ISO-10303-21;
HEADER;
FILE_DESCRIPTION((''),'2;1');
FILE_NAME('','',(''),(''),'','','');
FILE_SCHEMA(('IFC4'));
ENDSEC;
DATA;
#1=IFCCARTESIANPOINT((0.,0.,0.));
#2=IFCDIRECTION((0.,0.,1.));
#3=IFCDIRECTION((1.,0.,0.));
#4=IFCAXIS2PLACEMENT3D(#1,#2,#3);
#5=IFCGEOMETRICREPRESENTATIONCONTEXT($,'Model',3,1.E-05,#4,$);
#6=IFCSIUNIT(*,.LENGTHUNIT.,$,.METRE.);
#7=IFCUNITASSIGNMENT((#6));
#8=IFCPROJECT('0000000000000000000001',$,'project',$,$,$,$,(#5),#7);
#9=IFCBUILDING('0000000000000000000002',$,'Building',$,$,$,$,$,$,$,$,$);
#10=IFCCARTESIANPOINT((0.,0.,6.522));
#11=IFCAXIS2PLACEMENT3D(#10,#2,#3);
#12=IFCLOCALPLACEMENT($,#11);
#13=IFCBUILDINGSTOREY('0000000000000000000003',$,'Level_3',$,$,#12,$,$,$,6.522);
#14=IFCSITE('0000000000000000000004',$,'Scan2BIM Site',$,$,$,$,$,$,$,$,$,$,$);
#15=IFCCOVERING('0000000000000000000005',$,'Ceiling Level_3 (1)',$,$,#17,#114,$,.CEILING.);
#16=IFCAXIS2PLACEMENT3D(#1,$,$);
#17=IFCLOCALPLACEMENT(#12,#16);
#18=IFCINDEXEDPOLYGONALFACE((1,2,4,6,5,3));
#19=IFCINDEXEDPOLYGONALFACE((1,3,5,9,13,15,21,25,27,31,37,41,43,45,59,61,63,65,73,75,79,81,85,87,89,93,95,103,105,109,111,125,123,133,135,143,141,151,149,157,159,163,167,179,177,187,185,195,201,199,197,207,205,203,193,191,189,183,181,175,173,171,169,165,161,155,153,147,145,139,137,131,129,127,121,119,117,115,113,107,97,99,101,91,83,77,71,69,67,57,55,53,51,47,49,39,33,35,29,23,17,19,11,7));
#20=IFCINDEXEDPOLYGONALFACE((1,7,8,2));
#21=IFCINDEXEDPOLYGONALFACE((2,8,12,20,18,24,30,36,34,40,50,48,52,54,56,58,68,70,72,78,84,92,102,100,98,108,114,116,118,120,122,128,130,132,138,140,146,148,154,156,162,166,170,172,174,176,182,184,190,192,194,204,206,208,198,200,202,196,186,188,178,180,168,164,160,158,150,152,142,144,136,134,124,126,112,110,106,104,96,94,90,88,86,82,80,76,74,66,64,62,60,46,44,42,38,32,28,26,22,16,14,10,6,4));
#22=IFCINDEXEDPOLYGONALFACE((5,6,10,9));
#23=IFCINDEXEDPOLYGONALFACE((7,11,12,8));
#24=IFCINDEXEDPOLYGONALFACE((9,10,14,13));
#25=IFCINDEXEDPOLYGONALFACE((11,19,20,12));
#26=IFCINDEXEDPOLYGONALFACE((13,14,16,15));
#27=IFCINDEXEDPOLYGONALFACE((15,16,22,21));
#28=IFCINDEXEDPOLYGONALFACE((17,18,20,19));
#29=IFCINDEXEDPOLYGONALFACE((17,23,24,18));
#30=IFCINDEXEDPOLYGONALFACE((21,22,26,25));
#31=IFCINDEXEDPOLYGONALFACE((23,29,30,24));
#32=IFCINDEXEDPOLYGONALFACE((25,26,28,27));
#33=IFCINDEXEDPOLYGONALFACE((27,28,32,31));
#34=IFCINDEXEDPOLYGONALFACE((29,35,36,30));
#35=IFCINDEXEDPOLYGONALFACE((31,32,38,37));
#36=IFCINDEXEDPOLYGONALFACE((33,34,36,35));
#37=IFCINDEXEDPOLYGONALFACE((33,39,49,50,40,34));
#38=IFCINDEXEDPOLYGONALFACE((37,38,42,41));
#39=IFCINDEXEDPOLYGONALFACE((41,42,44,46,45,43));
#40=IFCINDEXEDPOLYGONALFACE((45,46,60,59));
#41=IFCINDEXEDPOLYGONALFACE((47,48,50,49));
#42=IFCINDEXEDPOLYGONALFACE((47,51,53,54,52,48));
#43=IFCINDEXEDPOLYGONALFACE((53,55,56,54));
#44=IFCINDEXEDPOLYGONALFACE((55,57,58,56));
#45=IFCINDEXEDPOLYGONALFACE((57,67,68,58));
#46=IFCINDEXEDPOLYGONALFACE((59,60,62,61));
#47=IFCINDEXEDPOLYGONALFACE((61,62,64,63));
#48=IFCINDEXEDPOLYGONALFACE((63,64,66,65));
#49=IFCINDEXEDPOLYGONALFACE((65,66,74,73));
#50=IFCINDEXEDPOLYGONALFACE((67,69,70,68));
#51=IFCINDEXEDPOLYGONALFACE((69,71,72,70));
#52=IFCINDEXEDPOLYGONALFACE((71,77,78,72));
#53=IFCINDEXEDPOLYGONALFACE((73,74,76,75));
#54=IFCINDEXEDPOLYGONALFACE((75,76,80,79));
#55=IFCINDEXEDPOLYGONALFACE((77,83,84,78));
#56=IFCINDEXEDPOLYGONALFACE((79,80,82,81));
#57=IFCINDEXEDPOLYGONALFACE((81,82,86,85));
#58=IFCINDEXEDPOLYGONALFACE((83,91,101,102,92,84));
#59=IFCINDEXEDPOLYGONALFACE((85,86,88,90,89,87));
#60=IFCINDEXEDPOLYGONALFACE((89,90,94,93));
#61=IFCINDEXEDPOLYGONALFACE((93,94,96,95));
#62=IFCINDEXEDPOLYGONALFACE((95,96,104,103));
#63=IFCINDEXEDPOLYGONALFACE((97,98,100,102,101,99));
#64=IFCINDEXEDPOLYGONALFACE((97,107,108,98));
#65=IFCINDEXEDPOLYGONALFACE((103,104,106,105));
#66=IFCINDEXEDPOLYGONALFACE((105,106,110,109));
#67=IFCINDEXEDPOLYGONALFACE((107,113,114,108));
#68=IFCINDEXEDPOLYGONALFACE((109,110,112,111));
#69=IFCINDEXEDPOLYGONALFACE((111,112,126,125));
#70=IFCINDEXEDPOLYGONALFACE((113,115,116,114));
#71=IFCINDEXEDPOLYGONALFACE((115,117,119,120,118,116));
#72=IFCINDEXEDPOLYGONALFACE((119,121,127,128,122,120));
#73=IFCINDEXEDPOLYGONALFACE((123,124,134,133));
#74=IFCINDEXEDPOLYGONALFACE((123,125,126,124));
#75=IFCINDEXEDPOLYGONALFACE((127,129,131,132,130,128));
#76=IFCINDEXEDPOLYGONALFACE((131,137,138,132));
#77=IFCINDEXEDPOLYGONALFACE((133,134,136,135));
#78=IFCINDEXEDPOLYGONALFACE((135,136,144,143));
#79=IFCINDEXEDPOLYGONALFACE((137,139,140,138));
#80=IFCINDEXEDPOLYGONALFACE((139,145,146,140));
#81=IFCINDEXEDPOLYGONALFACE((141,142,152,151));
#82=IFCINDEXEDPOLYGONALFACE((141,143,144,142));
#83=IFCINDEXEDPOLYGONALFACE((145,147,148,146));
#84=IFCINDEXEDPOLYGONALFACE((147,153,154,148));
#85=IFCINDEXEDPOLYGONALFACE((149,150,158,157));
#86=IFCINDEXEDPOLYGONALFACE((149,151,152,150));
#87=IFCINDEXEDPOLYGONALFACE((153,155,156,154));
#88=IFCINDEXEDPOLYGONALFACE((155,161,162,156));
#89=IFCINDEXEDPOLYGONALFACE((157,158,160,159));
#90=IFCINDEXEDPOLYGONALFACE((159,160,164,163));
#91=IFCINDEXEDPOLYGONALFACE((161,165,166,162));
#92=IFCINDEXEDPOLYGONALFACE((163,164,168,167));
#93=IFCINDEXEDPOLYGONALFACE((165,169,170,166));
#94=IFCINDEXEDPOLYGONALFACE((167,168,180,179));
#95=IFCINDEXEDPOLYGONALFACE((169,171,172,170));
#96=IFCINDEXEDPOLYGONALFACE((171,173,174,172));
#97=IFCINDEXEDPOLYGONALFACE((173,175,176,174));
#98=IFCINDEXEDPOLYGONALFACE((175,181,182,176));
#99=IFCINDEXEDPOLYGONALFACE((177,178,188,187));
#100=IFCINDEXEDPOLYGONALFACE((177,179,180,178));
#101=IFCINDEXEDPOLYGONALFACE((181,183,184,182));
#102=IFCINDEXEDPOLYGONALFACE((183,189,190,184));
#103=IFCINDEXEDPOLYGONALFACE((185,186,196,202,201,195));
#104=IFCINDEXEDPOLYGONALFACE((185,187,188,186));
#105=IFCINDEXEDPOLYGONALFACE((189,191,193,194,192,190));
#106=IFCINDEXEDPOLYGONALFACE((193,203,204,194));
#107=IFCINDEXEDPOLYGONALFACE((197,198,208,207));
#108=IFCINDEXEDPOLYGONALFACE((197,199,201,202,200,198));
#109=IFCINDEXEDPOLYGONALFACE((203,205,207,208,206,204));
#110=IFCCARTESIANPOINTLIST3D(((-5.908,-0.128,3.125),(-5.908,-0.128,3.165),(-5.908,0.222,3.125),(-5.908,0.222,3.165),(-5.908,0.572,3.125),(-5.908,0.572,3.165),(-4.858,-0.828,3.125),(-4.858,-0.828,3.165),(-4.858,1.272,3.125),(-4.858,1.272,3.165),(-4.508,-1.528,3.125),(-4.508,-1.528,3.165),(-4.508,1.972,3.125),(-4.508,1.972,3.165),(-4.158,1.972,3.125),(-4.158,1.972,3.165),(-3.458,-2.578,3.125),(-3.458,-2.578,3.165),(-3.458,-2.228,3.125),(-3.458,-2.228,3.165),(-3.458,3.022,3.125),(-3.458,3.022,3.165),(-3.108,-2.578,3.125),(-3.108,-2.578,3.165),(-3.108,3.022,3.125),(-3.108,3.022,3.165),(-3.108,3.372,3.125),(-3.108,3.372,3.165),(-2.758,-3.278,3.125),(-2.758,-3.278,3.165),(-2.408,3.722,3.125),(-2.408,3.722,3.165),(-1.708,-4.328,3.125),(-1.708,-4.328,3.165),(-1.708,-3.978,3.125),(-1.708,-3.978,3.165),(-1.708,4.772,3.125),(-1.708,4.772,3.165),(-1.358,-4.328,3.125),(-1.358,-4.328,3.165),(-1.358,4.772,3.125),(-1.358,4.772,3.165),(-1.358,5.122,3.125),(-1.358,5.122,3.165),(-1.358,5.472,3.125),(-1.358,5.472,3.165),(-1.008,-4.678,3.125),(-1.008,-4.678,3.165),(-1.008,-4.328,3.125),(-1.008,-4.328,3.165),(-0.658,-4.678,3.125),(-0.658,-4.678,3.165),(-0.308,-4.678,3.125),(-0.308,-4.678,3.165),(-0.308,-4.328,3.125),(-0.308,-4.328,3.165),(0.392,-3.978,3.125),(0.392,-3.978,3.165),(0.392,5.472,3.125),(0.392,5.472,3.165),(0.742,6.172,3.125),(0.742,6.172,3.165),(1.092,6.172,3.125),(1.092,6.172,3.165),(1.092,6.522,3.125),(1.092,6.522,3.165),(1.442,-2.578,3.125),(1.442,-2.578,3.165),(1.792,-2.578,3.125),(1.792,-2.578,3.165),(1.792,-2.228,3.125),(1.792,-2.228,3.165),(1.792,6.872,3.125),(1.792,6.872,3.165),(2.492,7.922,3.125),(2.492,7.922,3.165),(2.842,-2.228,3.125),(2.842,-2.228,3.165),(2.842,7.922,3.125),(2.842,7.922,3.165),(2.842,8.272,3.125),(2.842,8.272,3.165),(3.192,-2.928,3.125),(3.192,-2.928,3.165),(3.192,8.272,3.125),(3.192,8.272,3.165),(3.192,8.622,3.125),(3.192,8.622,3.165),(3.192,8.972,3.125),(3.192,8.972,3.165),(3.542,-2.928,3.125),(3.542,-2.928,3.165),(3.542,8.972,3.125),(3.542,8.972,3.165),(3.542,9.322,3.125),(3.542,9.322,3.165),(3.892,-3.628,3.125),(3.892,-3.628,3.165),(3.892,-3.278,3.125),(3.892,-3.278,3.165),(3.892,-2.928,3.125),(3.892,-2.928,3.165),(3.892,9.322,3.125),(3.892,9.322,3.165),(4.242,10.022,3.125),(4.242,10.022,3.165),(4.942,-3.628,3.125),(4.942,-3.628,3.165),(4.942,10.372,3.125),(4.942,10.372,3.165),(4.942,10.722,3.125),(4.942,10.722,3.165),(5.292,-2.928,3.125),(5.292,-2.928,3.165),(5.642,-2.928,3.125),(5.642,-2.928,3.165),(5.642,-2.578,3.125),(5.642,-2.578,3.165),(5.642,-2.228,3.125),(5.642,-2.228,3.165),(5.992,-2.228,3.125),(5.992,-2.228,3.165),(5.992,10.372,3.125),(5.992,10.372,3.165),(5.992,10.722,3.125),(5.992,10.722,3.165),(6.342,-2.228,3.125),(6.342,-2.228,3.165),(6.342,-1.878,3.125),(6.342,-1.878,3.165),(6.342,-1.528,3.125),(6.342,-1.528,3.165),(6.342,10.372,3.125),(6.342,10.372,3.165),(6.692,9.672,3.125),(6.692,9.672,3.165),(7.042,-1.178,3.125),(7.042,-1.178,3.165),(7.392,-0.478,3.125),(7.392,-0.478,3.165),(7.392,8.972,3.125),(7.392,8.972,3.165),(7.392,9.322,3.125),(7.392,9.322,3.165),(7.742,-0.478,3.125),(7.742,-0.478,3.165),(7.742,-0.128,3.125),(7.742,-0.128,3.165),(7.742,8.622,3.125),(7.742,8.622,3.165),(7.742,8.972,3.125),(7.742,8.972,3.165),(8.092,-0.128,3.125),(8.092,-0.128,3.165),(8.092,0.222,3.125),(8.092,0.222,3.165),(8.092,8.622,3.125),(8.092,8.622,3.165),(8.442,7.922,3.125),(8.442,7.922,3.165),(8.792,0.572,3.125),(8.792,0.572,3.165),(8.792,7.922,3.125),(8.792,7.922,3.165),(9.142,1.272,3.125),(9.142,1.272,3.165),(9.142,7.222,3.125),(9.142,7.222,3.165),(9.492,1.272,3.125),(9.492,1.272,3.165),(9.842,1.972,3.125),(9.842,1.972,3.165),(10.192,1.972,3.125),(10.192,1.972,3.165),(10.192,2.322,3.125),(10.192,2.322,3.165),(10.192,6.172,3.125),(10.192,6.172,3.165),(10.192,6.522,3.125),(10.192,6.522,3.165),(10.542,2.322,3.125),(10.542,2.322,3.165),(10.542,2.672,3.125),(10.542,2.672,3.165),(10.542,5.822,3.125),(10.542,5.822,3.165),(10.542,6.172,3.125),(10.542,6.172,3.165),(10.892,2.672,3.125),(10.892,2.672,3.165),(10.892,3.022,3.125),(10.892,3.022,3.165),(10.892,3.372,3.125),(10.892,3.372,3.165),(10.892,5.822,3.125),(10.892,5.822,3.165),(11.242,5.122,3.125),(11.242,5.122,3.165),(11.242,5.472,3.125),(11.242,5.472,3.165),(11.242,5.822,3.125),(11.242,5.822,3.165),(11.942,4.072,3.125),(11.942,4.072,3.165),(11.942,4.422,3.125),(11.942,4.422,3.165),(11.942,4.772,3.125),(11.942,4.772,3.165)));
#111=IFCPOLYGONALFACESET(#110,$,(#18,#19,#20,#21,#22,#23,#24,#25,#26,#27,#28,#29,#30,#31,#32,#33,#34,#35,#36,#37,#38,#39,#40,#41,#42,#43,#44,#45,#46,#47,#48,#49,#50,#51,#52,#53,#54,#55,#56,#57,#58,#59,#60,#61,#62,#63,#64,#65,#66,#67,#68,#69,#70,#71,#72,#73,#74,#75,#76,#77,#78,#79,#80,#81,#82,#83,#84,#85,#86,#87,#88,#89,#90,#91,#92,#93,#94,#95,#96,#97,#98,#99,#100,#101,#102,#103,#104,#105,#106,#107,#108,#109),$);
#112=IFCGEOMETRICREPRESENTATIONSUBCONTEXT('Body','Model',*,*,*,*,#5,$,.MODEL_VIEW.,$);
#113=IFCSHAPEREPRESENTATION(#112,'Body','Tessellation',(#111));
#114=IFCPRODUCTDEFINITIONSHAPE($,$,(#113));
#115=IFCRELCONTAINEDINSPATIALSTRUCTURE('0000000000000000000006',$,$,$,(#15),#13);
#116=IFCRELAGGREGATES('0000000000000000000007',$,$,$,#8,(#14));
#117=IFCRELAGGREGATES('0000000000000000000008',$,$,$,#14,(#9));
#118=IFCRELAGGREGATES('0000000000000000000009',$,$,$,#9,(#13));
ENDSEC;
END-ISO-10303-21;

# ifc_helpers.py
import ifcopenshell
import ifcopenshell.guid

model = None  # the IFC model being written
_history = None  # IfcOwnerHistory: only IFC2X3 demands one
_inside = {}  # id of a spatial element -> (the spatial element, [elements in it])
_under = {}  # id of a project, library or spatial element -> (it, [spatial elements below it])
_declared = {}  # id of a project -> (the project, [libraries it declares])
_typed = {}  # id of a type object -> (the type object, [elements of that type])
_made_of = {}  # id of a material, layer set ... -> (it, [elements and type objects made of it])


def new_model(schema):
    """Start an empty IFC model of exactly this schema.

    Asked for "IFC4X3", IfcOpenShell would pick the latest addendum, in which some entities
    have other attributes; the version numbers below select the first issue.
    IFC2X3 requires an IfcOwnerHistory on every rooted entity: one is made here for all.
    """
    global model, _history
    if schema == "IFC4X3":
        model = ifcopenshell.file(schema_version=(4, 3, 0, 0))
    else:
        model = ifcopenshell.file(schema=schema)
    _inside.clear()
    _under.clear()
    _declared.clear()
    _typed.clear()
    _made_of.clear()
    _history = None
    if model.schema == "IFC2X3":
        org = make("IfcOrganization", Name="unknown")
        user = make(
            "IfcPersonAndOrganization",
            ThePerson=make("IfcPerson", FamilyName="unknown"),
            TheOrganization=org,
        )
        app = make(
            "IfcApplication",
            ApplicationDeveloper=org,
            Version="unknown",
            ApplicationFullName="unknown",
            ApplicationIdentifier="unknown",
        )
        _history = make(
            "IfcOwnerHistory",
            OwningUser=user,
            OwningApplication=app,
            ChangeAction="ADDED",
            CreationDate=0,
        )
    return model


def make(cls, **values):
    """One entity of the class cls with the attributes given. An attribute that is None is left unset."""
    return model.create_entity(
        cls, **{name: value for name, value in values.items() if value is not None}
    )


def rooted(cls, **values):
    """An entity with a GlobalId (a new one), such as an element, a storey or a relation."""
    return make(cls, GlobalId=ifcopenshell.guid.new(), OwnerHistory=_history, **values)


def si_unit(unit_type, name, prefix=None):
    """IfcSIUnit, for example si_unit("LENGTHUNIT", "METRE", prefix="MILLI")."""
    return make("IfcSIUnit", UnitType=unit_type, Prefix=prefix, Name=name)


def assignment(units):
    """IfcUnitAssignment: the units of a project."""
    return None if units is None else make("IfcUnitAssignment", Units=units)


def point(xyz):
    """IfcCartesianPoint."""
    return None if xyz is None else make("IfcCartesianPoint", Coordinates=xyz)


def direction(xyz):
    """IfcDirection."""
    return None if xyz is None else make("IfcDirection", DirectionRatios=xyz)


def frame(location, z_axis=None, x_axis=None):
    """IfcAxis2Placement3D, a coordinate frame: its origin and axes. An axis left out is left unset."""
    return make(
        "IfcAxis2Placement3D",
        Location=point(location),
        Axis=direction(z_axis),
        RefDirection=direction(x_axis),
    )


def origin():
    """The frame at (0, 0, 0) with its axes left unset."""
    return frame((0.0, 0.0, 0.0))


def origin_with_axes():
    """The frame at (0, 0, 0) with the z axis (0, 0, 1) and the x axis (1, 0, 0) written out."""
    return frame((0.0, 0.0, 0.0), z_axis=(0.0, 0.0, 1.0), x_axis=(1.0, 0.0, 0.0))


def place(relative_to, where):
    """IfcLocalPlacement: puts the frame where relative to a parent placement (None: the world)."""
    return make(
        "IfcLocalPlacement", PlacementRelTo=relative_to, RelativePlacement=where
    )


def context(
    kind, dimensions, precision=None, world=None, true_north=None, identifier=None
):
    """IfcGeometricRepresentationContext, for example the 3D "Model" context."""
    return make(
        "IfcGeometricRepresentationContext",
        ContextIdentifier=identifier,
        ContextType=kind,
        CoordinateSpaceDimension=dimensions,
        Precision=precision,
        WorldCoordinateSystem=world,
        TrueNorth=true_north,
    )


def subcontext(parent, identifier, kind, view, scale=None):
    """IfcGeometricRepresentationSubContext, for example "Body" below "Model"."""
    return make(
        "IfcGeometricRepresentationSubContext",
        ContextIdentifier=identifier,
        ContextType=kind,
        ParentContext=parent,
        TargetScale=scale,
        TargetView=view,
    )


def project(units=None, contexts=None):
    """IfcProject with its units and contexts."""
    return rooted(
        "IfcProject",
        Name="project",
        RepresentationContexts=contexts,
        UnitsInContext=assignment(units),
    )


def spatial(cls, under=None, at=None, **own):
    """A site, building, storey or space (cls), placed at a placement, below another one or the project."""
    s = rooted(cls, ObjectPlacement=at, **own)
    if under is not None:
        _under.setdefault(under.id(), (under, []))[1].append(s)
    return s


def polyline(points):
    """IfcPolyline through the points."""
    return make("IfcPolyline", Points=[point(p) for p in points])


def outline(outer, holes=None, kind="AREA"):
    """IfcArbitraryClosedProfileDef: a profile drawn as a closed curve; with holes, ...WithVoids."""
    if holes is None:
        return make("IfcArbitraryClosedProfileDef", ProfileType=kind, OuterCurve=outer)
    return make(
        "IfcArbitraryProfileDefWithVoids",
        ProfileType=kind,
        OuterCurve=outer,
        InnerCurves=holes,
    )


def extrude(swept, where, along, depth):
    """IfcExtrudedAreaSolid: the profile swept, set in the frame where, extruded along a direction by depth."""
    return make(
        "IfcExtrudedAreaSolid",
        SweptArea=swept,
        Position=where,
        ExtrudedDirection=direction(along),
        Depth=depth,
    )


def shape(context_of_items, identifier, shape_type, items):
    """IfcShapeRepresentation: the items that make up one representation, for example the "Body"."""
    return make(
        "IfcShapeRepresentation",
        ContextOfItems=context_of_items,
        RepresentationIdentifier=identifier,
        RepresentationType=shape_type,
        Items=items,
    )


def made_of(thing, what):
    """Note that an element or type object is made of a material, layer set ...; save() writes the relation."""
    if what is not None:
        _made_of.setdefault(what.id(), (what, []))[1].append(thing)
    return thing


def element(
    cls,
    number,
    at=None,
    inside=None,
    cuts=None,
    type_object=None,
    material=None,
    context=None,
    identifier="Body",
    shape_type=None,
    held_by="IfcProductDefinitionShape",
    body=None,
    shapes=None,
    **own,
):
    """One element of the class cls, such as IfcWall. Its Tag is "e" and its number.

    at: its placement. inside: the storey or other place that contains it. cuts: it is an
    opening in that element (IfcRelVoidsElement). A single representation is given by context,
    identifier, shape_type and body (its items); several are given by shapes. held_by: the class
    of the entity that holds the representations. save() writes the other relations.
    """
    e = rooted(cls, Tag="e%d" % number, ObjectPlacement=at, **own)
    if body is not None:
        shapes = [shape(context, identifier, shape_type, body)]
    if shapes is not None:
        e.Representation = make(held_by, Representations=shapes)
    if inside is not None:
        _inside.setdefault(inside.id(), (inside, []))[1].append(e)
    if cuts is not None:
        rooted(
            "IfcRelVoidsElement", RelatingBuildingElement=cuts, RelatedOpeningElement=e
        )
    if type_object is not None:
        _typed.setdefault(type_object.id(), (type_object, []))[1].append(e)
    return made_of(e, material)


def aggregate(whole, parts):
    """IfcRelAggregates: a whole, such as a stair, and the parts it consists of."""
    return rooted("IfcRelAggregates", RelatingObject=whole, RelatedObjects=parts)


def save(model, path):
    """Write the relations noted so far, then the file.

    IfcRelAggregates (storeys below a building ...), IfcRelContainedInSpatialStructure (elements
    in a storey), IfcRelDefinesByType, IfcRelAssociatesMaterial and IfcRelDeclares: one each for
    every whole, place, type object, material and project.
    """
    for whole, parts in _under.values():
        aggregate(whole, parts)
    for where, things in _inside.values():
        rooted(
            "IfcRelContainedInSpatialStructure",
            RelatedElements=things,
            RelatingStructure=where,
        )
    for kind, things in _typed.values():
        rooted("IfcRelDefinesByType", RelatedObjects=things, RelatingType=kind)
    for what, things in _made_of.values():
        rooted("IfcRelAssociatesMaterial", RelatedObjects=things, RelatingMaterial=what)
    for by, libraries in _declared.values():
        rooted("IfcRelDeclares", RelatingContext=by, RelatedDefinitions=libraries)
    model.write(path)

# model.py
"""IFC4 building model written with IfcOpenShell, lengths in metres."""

from ifc_helpers import new_model, si_unit, frame, origin, origin_with_axes, place, context, subcontext, project, spatial, polyline, outline, extrude, element, save


model = new_model("IFC4")

# Units and contexts
model_context = context("Model", 3, precision=1e-05, world=origin_with_axes())
body_context = subcontext(model_context, "Body", "Model", "MODEL_VIEW")
ifc_project = project(units=[si_unit("LENGTHUNIT", "METRE")], contexts=[model_context])

# Site, building, storey
site = spatial("IfcSite", under=ifc_project, Name="Scan2BIM Site")
building = spatial("IfcBuilding", under=site, Name="Building")
storey_placement = place(None, frame((0.0, 0.0, 6.522), z_axis=(0.0, 0.0, 1.0), x_axis=(1.0, 0.0, 0.0)))
storey = spatial("IfcBuildingStorey", under=building, at=storey_placement, Name="Level_3", Elevation=6.522)

# Covering
covering_placement = place(storey_placement, frame((0.0, 0.0, 3.125), z_axis=(0.0, 0.0, 1.0), x_axis=(1.0, 0.0, 0.0)))
element("IfcCovering", 1, at=covering_placement, inside=storey, Name="Ceiling Level_3 (1)", PredefinedType="CEILING", context=body_context, shape_type="SweptSolid", body=[
    extrude(outline(polyline([(-1.008, -4.678), (-0.658, -4.678), (-0.308, -4.678), (-0.308, -4.328), (0.392, -3.978), (1.442, -2.578), (1.792, -2.578), (1.792, -2.228), (2.842, -2.228), (3.192, -2.928), (3.542, -2.928), (3.892, -2.928), (3.892, -3.278), (3.892, -3.628), (4.942, -3.628), (5.292, -2.928), (5.642, -2.928), (5.642, -2.578), (5.642, -2.228), (5.992, -2.228), (6.342, -2.228), (6.342, -1.878), (6.342, -1.528), (7.042, -1.178), (7.392, -0.478), (7.742, -0.478), (7.742, -0.128), (8.092, -0.128), (8.092, 0.222), (8.792, 0.572), (9.142, 1.272), (9.492, 1.272), (9.842, 1.972), (10.192, 1.972), (10.192, 2.322), (10.542, 2.322), (10.542, 2.672), (10.892, 2.672), (10.892, 3.022), (10.892, 3.372), (11.942, 4.072), (11.942, 4.422), (11.942, 4.772), (11.242, 5.122), (11.242, 5.472), (11.242, 5.822), (10.892, 5.822), (10.542, 5.822), (10.542, 6.172), (10.192, 6.172), (10.192, 6.522), (9.142, 7.222), (8.792, 7.922), (8.442, 7.922), (8.092, 8.622), (7.742, 8.622), (7.742, 8.972), (7.392, 8.972), (7.392, 9.322), (6.692, 9.672), (6.342, 10.372), (5.992, 10.372), (5.992, 10.722), (4.942, 10.722), (4.942, 10.372), (4.242, 10.022), (3.892, 9.322), (3.542, 9.322), (3.542, 8.972), (3.192, 8.972), (3.192, 8.622), (3.192, 8.272), (2.842, 8.272), (2.842, 7.922), (2.492, 7.922), (1.792, 6.872), (1.092, 6.522), (1.092, 6.172), (0.742, 6.172), (0.392, 5.472), (-1.358, 5.472), (-1.358, 5.122), (-1.358, 4.772), (-1.708, 4.772), (-2.408, 3.722), (-3.108, 3.372), (-3.108, 3.022), (-3.458, 3.022), (-4.158, 1.972), (-4.508, 1.972), (-4.858, 1.272), (-5.908, 0.572), (-5.908, 0.222), (-5.908, -0.128), (-4.858, -0.828), (-4.508, -1.528), (-3.458, -2.228), (-3.458, -2.578), (-3.108, -2.578), (-2.758, -3.278), (-1.708, -3.978), (-1.708, -4.328), (-1.358, -4.328), (-1.008, -4.328), (-1.008, -4.678)])), origin(), (0.0, 0.0, 1.0), 0.04),
])

save(model, "model.ifc")
